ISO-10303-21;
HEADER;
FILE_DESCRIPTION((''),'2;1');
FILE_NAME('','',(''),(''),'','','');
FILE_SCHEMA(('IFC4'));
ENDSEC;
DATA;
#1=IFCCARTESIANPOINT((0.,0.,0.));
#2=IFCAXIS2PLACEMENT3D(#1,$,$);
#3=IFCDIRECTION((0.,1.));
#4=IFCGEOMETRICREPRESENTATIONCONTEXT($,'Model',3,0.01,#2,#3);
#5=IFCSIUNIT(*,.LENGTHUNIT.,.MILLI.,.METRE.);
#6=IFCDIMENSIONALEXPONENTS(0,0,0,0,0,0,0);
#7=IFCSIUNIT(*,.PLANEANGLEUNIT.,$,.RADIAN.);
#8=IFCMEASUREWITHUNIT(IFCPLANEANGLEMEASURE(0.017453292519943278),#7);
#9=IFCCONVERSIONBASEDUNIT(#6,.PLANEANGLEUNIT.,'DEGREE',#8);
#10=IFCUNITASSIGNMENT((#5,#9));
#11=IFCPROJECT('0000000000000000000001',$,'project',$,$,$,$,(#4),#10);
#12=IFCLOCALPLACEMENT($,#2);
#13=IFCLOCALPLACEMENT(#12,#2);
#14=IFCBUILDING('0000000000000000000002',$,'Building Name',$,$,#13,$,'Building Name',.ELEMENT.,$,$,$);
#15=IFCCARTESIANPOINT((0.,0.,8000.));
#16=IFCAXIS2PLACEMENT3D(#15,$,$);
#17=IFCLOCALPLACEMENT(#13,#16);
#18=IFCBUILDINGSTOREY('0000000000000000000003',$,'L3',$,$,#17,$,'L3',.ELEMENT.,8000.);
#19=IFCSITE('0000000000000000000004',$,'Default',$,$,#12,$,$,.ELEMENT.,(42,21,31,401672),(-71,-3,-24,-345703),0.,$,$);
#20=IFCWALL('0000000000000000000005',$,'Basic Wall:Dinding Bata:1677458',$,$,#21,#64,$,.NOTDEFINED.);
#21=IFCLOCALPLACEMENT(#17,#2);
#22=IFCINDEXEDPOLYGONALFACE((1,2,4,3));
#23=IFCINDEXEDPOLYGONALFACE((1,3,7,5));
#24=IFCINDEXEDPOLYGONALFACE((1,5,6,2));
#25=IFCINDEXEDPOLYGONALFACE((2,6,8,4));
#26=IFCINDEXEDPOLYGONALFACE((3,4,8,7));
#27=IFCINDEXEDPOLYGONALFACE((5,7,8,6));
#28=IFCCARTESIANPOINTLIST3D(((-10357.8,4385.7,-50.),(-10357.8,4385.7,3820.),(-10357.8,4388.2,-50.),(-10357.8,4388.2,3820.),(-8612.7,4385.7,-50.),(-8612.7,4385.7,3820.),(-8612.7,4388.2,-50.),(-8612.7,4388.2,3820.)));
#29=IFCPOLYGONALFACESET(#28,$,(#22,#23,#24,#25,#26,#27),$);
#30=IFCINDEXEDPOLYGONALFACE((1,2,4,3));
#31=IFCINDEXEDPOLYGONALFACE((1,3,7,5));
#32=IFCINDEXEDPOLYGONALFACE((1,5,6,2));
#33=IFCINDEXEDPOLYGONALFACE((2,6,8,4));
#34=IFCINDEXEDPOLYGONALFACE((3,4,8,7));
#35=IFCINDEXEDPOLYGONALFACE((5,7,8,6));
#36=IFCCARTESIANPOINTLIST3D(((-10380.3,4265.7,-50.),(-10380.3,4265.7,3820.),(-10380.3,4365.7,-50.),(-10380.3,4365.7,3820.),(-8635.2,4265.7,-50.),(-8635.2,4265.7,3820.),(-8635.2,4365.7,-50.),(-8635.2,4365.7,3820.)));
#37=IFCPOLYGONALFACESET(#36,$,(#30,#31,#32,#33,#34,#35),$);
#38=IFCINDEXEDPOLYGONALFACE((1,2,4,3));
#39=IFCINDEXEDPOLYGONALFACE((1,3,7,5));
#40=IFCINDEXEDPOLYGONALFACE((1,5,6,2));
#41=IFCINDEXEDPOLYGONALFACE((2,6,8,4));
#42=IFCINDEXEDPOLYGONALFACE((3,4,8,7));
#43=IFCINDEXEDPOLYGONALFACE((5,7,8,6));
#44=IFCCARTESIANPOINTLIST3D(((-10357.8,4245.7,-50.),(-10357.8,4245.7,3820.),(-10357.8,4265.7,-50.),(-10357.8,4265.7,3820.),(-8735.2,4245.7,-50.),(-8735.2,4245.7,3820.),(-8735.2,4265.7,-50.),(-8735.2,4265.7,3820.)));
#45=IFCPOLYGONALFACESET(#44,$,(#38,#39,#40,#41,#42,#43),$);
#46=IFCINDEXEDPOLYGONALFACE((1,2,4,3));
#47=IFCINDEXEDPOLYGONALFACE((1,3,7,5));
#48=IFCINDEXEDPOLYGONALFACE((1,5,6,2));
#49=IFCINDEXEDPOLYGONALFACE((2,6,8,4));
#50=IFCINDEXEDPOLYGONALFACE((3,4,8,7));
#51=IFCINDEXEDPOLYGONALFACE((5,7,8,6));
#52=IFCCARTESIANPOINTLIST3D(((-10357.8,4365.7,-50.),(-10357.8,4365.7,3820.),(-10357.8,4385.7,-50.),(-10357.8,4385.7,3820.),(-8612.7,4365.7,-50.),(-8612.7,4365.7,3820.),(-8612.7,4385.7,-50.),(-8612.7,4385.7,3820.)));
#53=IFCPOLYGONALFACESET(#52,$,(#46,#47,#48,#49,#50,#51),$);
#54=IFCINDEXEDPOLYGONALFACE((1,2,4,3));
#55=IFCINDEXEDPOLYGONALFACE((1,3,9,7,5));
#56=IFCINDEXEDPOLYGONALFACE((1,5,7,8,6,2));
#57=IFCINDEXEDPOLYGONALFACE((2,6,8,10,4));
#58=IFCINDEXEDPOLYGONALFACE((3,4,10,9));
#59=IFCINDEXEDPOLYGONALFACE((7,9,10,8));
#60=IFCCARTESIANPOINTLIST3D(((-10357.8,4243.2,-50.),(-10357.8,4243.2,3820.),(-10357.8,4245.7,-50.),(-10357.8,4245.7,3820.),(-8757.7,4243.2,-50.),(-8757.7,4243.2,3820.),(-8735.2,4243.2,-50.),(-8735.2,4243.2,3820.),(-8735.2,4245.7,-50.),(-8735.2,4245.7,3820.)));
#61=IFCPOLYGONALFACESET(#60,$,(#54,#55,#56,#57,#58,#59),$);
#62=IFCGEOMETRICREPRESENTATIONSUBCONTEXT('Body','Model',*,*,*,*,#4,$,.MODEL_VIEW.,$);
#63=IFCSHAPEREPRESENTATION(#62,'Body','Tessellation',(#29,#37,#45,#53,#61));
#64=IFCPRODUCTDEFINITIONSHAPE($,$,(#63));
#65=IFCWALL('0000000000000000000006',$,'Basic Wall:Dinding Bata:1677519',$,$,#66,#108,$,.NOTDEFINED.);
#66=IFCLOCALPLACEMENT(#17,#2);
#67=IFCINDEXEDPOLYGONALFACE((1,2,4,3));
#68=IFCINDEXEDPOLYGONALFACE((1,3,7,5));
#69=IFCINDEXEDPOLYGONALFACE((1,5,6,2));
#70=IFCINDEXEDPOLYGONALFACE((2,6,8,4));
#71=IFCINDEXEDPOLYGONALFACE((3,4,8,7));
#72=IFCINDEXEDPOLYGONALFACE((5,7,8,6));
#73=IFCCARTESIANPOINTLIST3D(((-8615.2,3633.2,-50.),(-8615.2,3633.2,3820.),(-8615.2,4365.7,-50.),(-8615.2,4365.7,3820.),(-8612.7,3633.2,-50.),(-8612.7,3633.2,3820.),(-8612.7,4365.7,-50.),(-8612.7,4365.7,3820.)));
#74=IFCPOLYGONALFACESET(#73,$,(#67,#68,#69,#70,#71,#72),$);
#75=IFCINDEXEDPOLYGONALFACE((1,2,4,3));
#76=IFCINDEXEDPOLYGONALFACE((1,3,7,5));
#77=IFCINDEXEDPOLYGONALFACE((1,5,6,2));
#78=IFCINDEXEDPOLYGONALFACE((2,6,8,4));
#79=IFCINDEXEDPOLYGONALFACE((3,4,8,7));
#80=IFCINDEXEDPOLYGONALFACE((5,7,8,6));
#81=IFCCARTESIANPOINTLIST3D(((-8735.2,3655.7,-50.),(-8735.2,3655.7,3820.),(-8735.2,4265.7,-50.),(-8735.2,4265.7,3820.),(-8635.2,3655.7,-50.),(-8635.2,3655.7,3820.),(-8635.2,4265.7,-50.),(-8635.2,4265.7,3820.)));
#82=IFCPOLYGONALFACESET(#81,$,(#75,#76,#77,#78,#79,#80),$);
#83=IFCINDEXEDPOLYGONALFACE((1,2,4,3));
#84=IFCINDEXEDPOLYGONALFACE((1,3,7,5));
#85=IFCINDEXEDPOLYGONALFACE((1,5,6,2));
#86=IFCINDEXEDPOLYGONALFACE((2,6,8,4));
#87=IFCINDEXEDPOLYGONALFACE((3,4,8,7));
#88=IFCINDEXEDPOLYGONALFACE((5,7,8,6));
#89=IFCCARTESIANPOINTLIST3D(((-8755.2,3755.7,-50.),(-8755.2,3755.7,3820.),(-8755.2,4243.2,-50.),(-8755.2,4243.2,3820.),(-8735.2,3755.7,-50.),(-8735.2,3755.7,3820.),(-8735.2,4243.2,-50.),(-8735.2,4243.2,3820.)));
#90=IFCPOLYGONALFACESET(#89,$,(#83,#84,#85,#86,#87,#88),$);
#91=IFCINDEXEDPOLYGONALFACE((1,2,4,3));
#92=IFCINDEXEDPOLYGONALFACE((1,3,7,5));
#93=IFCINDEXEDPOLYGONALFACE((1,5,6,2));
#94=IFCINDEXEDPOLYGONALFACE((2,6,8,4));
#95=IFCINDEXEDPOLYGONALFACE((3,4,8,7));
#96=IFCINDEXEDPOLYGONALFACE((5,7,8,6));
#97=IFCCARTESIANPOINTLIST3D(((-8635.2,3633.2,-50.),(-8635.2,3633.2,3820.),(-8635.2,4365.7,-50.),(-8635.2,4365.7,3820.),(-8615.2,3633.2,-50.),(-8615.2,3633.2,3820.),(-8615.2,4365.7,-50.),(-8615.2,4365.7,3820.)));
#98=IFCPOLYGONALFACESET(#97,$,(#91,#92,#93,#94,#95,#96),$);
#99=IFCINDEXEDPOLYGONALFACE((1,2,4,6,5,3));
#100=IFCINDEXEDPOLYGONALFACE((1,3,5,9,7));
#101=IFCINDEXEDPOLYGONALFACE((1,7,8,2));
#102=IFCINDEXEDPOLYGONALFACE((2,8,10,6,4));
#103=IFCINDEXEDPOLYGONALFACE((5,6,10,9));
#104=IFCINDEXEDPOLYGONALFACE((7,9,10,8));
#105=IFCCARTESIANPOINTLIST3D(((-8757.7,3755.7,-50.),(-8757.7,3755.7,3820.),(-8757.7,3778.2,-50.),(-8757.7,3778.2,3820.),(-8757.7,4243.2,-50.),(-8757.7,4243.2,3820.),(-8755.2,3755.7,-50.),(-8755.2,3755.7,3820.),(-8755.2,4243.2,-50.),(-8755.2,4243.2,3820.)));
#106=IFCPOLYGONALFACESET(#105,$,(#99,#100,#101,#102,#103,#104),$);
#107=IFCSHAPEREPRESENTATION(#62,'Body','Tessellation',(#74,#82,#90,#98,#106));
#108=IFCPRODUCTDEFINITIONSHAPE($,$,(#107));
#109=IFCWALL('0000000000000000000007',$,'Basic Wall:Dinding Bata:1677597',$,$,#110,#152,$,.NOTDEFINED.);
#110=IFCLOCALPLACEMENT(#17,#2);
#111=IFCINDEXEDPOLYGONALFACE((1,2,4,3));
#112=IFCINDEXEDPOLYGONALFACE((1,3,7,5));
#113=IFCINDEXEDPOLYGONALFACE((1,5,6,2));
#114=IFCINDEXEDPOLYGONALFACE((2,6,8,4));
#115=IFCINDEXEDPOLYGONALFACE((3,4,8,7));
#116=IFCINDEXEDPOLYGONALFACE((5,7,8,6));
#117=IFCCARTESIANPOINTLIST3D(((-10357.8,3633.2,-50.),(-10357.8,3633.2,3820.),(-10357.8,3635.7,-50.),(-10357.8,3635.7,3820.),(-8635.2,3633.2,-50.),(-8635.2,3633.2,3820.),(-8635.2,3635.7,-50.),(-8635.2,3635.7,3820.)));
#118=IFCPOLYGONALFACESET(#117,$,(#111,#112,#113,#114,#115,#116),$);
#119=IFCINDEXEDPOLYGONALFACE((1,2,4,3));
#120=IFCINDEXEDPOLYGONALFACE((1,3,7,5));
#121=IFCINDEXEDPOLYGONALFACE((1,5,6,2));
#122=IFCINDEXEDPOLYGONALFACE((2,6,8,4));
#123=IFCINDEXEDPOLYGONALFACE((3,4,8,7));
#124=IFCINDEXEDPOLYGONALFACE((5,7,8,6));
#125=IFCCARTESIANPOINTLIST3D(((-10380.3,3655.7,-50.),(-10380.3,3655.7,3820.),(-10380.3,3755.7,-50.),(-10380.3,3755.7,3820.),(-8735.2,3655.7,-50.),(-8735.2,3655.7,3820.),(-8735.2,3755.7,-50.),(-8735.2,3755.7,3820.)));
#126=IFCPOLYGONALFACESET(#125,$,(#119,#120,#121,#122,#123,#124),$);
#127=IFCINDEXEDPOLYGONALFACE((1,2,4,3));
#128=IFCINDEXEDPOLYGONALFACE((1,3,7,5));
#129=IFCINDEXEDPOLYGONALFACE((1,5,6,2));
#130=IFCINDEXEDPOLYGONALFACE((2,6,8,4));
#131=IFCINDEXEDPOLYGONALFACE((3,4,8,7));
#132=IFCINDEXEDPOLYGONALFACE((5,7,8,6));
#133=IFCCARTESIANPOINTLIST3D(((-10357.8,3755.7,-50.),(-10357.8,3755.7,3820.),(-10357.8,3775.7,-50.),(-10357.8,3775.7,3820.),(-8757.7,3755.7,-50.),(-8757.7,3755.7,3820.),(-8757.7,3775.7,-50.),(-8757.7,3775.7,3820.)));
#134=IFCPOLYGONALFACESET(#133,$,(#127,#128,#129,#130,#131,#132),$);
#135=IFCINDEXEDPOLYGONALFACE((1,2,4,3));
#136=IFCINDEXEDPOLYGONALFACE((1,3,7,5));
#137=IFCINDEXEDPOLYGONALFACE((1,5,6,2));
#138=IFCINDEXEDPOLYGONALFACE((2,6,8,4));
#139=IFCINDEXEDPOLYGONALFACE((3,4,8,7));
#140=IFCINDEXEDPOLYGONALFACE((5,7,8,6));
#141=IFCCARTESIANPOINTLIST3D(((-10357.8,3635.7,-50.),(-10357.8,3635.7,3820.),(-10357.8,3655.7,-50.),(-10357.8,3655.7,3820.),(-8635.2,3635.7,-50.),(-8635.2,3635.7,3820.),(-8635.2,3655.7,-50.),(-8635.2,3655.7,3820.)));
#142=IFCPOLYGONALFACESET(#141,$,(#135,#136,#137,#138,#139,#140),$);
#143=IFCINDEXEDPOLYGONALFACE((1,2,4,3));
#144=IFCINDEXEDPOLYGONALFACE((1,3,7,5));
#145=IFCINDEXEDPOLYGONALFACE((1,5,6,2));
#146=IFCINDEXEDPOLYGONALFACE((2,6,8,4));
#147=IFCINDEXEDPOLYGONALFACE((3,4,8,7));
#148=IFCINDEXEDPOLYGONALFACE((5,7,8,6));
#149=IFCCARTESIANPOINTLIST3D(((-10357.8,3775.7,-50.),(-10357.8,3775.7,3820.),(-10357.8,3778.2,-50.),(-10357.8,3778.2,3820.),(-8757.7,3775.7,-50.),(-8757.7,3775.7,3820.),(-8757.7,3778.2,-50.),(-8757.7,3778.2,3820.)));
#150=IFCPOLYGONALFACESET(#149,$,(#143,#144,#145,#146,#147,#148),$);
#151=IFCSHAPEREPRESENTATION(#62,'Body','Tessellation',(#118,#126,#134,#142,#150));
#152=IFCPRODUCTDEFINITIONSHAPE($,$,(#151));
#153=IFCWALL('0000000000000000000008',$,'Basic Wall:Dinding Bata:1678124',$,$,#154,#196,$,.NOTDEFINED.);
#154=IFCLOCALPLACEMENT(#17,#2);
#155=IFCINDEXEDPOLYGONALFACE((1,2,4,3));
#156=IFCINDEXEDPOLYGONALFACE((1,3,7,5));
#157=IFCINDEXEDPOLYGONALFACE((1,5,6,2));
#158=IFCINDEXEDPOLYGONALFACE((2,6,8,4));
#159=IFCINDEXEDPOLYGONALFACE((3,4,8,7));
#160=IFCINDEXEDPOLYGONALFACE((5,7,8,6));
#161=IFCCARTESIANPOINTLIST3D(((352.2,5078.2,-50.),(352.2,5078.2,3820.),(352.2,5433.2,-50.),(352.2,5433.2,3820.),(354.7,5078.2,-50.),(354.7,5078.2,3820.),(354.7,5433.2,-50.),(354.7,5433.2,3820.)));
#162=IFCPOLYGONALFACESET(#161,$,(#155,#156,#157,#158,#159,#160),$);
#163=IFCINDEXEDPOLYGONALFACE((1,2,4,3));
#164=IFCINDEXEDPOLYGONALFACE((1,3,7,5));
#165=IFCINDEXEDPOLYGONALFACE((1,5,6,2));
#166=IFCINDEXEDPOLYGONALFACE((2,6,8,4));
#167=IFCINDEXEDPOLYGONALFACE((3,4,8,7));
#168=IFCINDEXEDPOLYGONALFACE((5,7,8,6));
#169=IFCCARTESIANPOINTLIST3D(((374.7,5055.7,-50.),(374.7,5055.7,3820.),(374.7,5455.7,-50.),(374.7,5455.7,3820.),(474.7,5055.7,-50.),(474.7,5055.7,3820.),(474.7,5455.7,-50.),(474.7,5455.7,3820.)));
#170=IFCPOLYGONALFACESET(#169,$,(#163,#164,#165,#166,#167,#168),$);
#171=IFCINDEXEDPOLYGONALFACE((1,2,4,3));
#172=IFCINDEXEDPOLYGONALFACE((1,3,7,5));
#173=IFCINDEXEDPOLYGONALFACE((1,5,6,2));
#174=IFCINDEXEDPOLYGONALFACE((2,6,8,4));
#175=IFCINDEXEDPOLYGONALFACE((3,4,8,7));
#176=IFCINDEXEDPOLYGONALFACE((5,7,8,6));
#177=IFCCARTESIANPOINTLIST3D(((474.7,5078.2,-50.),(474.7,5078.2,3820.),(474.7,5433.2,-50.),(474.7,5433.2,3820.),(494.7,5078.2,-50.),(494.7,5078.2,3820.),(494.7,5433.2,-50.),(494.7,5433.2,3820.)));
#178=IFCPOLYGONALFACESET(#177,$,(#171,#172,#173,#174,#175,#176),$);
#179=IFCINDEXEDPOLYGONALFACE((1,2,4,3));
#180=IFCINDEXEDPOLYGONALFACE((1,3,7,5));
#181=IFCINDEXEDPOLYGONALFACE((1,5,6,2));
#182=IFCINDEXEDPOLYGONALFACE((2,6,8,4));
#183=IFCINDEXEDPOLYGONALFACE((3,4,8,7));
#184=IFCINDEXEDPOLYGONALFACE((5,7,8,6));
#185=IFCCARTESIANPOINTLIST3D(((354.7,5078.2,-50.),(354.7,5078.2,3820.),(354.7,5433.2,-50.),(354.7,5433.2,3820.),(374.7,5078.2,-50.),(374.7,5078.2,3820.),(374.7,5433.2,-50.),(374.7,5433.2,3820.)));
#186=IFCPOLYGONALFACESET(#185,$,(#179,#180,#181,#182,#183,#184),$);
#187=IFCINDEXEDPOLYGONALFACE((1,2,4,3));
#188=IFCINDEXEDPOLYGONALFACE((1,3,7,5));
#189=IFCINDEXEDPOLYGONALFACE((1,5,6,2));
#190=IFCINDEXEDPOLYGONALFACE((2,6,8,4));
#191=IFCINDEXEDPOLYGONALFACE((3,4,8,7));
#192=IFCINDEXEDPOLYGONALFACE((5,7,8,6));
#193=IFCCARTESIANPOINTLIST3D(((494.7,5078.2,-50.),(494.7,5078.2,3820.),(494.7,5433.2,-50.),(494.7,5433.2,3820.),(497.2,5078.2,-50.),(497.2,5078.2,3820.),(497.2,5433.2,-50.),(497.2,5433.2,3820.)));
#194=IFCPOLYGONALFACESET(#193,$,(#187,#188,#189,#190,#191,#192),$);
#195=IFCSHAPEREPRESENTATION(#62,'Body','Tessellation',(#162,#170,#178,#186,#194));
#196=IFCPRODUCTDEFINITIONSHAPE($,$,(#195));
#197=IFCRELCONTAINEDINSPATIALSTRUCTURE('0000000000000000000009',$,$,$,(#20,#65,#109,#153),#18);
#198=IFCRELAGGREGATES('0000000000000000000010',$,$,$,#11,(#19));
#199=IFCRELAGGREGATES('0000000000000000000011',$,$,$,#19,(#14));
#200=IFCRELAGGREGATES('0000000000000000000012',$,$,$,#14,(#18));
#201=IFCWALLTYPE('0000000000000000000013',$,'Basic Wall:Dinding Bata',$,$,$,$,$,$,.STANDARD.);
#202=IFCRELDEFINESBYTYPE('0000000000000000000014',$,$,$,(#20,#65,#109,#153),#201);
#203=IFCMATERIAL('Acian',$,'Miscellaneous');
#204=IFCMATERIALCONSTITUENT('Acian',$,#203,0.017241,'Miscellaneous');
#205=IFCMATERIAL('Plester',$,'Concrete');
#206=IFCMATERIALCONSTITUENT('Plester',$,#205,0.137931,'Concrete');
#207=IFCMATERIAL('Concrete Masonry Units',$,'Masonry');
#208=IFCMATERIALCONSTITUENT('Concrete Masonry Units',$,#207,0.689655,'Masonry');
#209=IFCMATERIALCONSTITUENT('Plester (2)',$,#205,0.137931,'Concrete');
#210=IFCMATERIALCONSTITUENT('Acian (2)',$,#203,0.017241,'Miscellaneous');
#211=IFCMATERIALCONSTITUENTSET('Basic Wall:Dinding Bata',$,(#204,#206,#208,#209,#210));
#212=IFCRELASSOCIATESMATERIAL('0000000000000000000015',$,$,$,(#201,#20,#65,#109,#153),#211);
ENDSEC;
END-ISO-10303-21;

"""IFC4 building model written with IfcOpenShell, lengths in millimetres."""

from ifc_helpers import new_model, entity, si_unit, converted_unit, direction, frame, origin, place, context, subcontext, project, spatial, indexed_curve, outline, extrude, material, constituent, constituent_set, type_object, element, save


model = new_model("IFC4")

# Units and contexts
model_context = context("Model", 3, precision=0.01, world=origin(), true_north=direction((0.0, 1.0)))
body_context = subcontext(model_context, "Body", "Model", "MODEL_VIEW")
ifc_project = project(units=[si_unit("LENGTHUNIT", "METRE", prefix="MILLI"), converted_unit("PLANEANGLEUNIT", "DEGREE", entity("IfcPlaneAngleMeasure", 0.017453292519943278), si_unit("PLANEANGLEUNIT", "RADIAN"), dimensions=[0, 0, 0, 0, 0, 0, 0])], contexts=[model_context])

# Site, building, storey
site_placement = place(None, origin())
site = spatial("IfcSite", under=ifc_project, at=site_placement, Name="Default", CompositionType="ELEMENT", RefLatitude=(42, 21, 31, 401672), RefLongitude=(-71, -3, -24, -345703), RefElevation=0.0)
building_placement = place(site_placement, origin())
building = spatial("IfcBuilding", under=site, at=building_placement, Name="Building Name", LongName="Building Name", CompositionType="ELEMENT")
storey_placement = place(building_placement, frame((0.0, 0.0, 8000.0)))
storey = spatial("IfcBuildingStorey", under=building, at=storey_placement, Name="L3", LongName="L3", CompositionType="ELEMENT", Elevation=8000.0)

# Walls
ifc_material_1 = material(Name="Acian", Category="Miscellaneous")
ifc_constituent_1 = constituent(ifc_material_1, Name="Acian", Category="Miscellaneous", fraction=0.017241)
ifc_material_2 = material(Name="Plester", Category="Concrete")
ifc_constituent_2 = constituent(ifc_material_2, Name="Plester", Category="Concrete", fraction=0.137931)
ifc_material_3 = material(Name="Concrete Masonry Units", Category="Masonry")
ifc_constituent_3 = constituent(ifc_material_3, Name="Concrete Masonry Units", Category="Masonry", fraction=0.689655)
ifc_constituent_4 = constituent(ifc_material_2, Name="Plester (2)", Category="Concrete", fraction=0.137931)
ifc_constituent_5 = constituent(ifc_material_1, Name="Acian (2)", Category="Miscellaneous", fraction=0.017241)
ifc_constituent_set = constituent_set(constituents=[ifc_constituent_1, ifc_constituent_2, ifc_constituent_3, ifc_constituent_4, ifc_constituent_5], Name="Basic Wall:Dinding Bata")
wall_type = type_object("IfcWallType", Name="Basic Wall:Dinding Bata", PredefinedType="STANDARD", material=ifc_constituent_set)
wall_1_placement = place(storey_placement, frame((-10357.8, 4315.7, -50.0)))
element("IfcWall", 1, at=wall_1_placement, inside=storey, type_object=wall_type, material=ifc_constituent_set, Name="Basic Wall:Dinding Bata:1677458", PredefinedType="NOTDEFINED", context=body_context, shape_type="SweptSolid", body=[
    extrude(outline(indexed_curve([(-1.3, -872.5), (1.2, -872.5), (1.3, 872.5), (-1.2, 872.5), (-1.3, -872.5)], self_intersect=False)), frame((872.5, 71.3, 0.0), z_axis=(0.0, 0.0, 1.0), x_axis=(0.0, -1.0, 0.0)), (0.0, 0.0, 1.0), 3870.0),
    extrude(outline(indexed_curve([(-872.5, -50.0), (872.5, -50.0), (872.5, 50.0), (-872.5, 50.0), (-872.5, -50.0)], self_intersect=False)), frame((850.0, 0.0, 0.0)), (0.0, 0.0, 1.0), 3870.0),
    extrude(outline(indexed_curve([(-811.3, -10.0), (811.3, -10.0), (811.3, 10.0), (-811.3, 10.0), (-811.3, -10.0)], self_intersect=False)), frame((811.3, -60.0, 0.0)), (0.0, 0.0, 1.0), 3870.0),
    extrude(outline(indexed_curve([(-872.5, -10.0), (872.5, -10.0), (872.5, 10.0), (-872.5, 10.0), (-872.5, -10.0)], self_intersect=False)), frame((872.5, 60.0, 0.0)), (0.0, 0.0, 1.0), 3870.0),
    extrude(outline(indexed_curve([(631.0, -1.0), (653.5, -1.0), (653.5, 1.5), (-969.0, 1.5), (-969.0, -1.0), (631.0, -1.0)], self_intersect=False)), frame((969.0, -71.5, 0.0)), (0.0, 0.0, 1.0), 3870.0),
])
wall_2_placement = place(storey_placement, frame((-8685.2, 4243.2, -50.0), z_axis=(0.0, 0.0, 1.0), x_axis=(0.0, -1.0, 0.0)))
element("IfcWall", 2, at=wall_2_placement, inside=storey, type_object=wall_type, material=ifc_constituent_set, Name="Basic Wall:Dinding Bata:1677519", PredefinedType="NOTDEFINED", context=body_context, shape_type="SweptSolid", body=[
    extrude(outline(indexed_curve([(-1.3, -366.3), (1.2, -366.3), (1.2, 366.3), (-1.2, 366.3), (-1.3, -366.3)], self_intersect=False)), frame((243.8, 71.2, 0.0), z_axis=(0.0, 0.0, 1.0), x_axis=(0.0, -1.0, 0.0)), (0.0, 0.0, 1.0), 3870.0),
    extrude(outline(indexed_curve([(-305.0, -50.0), (305.0, -50.0), (305.0, 50.0), (-305.0, 50.0), (-305.0, -50.0)], self_intersect=False)), frame((282.5, 0.0, 0.0)), (0.0, 0.0, 1.0), 3870.0),
    extrude(outline(indexed_curve([(-243.8, -10.0), (243.8, -10.0), (243.8, 10.0), (-243.8, 10.0), (-243.8, -10.0)], self_intersect=False)), frame((243.8, -60.0, 0.0)), (0.0, 0.0, 1.0), 3870.0),
    extrude(outline(indexed_curve([(-366.3, -10.0), (366.3, -10.0), (366.3, 10.0), (-366.3, 10.0), (-366.3, -10.0)], self_intersect=False)), frame((243.8, 60.0, 0.0)), (0.0, 0.0, 1.0), 3870.0),
    extrude(outline(indexed_curve([(177.0, -1.0), (199.5, -1.0), (199.5, 1.5), (-288.0, 1.5), (-288.0, -1.0), (177.0, -1.0)], self_intersect=False)), frame((288.0, -71.5, 0.0)), (0.0, 0.0, 1.0), 3870.0),
])
wall_3_placement = place(storey_placement, frame((-8757.7, 3705.7, -50.0), z_axis=(0.0, 0.0, 1.0), x_axis=(-1.0, 0.0, 0.0)))
element("IfcWall", 3, at=wall_3_placement, inside=storey, type_object=wall_type, material=ifc_constituent_set, Name="Basic Wall:Dinding Bata:1677597", PredefinedType="NOTDEFINED", context=body_context, shape_type="SweptSolid", body=[
    extrude(outline(indexed_curve([(-1.3, -861.3), (1.2, -861.3), (1.3, 861.3), (-1.2, 861.3), (-1.3, -861.3)], self_intersect=False)), frame((738.8, 71.2, 0.0), z_axis=(0.0, 0.0, 1.0), x_axis=(0.0, -1.0, 0.0)), (0.0, 0.0, 1.0), 3870.0),
    extrude(outline(indexed_curve([(-822.5, -50.0), (822.5, -50.0), (822.5, 50.0), (-822.5, 50.0), (-822.5, -50.0)], self_intersect=False)), frame((800.0, 0.0, 0.0)), (0.0, 0.0, 1.0), 3870.0),
    extrude(outline(indexed_curve([(-800.0, -10.0), (800.0, -10.0), (800.0, 10.0), (-800.0, 10.0), (-800.0, -10.0)], self_intersect=False)), frame((800.0, -60.0, 0.0)), (0.0, 0.0, 1.0), 3870.0),
    extrude(outline(indexed_curve([(-861.3, -10.0), (861.3, -10.0), (861.3, 10.0), (-861.3, 10.0), (-861.3, -10.0)], self_intersect=False)), frame((738.8, 60.0, 0.0)), (0.0, 0.0, 1.0), 3870.0),
    extrude(outline(indexed_curve([(-1.3, -800.0), (1.2, -800.0), (1.3, 800.0), (-1.2, 800.0), (-1.3, -800.0)], self_intersect=False)), frame((800.0, -71.3, 0.0), z_axis=(0.0, 0.0, 1.0), x_axis=(0.0, 1.0, 0.0)), (0.0, 0.0, 1.0), 3870.0),
])
wall_4_placement = place(storey_placement, frame((424.7, 5078.2, -50.0), z_axis=(0.0, 0.0, 1.0), x_axis=(0.0, 1.0, 0.0)))
element("IfcWall", 4, at=wall_4_placement, inside=storey, type_object=wall_type, material=ifc_constituent_set, Name="Basic Wall:Dinding Bata:1678124", PredefinedType="NOTDEFINED", context=body_context, shape_type="SweptSolid", body=[
    extrude(outline(indexed_curve([(-1.3, -177.5), (1.2, -177.5), (1.3, 177.5), (-1.2, 177.5), (-1.3, -177.5)], self_intersect=False)), frame((177.5, 71.2, 0.0), z_axis=(0.0, 0.0, 1.0), x_axis=(0.0, -1.0, 0.0)), (0.0, 0.0, 1.0), 3870.0),
    extrude(outline(indexed_curve([(-200.0, -50.0), (200.0, -50.0), (200.0, 50.0), (-200.0, 50.0), (-200.0, -50.0)], self_intersect=False)), frame((177.5, 0.0, 0.0)), (0.0, 0.0, 1.0), 3870.0),
    extrude(outline(indexed_curve([(-177.5, -10.0), (177.5, -10.0), (177.5, 10.0), (-177.5, 10.0), (-177.5, -10.0)], self_intersect=False)), frame((177.5, -60.0, 0.0)), (0.0, 0.0, 1.0), 3870.0),
    extrude(outline(indexed_curve([(-177.5, -10.0), (177.5, -10.0), (177.5, 10.0), (-177.5, 10.0), (-177.5, -10.0)], self_intersect=False)), frame((177.5, 60.0, 0.0)), (0.0, 0.0, 1.0), 3870.0),
    extrude(outline(indexed_curve([(-1.3, -177.5), (1.2, -177.5), (1.3, 177.5), (-1.2, 177.5), (-1.3, -177.5)], self_intersect=False)), frame((177.5, -71.2, 0.0), z_axis=(0.0, 0.0, 1.0), x_axis=(0.0, 1.0, 0.0)), (0.0, 0.0, 1.0), 3870.0),
])

save(model, "model.ifc")
